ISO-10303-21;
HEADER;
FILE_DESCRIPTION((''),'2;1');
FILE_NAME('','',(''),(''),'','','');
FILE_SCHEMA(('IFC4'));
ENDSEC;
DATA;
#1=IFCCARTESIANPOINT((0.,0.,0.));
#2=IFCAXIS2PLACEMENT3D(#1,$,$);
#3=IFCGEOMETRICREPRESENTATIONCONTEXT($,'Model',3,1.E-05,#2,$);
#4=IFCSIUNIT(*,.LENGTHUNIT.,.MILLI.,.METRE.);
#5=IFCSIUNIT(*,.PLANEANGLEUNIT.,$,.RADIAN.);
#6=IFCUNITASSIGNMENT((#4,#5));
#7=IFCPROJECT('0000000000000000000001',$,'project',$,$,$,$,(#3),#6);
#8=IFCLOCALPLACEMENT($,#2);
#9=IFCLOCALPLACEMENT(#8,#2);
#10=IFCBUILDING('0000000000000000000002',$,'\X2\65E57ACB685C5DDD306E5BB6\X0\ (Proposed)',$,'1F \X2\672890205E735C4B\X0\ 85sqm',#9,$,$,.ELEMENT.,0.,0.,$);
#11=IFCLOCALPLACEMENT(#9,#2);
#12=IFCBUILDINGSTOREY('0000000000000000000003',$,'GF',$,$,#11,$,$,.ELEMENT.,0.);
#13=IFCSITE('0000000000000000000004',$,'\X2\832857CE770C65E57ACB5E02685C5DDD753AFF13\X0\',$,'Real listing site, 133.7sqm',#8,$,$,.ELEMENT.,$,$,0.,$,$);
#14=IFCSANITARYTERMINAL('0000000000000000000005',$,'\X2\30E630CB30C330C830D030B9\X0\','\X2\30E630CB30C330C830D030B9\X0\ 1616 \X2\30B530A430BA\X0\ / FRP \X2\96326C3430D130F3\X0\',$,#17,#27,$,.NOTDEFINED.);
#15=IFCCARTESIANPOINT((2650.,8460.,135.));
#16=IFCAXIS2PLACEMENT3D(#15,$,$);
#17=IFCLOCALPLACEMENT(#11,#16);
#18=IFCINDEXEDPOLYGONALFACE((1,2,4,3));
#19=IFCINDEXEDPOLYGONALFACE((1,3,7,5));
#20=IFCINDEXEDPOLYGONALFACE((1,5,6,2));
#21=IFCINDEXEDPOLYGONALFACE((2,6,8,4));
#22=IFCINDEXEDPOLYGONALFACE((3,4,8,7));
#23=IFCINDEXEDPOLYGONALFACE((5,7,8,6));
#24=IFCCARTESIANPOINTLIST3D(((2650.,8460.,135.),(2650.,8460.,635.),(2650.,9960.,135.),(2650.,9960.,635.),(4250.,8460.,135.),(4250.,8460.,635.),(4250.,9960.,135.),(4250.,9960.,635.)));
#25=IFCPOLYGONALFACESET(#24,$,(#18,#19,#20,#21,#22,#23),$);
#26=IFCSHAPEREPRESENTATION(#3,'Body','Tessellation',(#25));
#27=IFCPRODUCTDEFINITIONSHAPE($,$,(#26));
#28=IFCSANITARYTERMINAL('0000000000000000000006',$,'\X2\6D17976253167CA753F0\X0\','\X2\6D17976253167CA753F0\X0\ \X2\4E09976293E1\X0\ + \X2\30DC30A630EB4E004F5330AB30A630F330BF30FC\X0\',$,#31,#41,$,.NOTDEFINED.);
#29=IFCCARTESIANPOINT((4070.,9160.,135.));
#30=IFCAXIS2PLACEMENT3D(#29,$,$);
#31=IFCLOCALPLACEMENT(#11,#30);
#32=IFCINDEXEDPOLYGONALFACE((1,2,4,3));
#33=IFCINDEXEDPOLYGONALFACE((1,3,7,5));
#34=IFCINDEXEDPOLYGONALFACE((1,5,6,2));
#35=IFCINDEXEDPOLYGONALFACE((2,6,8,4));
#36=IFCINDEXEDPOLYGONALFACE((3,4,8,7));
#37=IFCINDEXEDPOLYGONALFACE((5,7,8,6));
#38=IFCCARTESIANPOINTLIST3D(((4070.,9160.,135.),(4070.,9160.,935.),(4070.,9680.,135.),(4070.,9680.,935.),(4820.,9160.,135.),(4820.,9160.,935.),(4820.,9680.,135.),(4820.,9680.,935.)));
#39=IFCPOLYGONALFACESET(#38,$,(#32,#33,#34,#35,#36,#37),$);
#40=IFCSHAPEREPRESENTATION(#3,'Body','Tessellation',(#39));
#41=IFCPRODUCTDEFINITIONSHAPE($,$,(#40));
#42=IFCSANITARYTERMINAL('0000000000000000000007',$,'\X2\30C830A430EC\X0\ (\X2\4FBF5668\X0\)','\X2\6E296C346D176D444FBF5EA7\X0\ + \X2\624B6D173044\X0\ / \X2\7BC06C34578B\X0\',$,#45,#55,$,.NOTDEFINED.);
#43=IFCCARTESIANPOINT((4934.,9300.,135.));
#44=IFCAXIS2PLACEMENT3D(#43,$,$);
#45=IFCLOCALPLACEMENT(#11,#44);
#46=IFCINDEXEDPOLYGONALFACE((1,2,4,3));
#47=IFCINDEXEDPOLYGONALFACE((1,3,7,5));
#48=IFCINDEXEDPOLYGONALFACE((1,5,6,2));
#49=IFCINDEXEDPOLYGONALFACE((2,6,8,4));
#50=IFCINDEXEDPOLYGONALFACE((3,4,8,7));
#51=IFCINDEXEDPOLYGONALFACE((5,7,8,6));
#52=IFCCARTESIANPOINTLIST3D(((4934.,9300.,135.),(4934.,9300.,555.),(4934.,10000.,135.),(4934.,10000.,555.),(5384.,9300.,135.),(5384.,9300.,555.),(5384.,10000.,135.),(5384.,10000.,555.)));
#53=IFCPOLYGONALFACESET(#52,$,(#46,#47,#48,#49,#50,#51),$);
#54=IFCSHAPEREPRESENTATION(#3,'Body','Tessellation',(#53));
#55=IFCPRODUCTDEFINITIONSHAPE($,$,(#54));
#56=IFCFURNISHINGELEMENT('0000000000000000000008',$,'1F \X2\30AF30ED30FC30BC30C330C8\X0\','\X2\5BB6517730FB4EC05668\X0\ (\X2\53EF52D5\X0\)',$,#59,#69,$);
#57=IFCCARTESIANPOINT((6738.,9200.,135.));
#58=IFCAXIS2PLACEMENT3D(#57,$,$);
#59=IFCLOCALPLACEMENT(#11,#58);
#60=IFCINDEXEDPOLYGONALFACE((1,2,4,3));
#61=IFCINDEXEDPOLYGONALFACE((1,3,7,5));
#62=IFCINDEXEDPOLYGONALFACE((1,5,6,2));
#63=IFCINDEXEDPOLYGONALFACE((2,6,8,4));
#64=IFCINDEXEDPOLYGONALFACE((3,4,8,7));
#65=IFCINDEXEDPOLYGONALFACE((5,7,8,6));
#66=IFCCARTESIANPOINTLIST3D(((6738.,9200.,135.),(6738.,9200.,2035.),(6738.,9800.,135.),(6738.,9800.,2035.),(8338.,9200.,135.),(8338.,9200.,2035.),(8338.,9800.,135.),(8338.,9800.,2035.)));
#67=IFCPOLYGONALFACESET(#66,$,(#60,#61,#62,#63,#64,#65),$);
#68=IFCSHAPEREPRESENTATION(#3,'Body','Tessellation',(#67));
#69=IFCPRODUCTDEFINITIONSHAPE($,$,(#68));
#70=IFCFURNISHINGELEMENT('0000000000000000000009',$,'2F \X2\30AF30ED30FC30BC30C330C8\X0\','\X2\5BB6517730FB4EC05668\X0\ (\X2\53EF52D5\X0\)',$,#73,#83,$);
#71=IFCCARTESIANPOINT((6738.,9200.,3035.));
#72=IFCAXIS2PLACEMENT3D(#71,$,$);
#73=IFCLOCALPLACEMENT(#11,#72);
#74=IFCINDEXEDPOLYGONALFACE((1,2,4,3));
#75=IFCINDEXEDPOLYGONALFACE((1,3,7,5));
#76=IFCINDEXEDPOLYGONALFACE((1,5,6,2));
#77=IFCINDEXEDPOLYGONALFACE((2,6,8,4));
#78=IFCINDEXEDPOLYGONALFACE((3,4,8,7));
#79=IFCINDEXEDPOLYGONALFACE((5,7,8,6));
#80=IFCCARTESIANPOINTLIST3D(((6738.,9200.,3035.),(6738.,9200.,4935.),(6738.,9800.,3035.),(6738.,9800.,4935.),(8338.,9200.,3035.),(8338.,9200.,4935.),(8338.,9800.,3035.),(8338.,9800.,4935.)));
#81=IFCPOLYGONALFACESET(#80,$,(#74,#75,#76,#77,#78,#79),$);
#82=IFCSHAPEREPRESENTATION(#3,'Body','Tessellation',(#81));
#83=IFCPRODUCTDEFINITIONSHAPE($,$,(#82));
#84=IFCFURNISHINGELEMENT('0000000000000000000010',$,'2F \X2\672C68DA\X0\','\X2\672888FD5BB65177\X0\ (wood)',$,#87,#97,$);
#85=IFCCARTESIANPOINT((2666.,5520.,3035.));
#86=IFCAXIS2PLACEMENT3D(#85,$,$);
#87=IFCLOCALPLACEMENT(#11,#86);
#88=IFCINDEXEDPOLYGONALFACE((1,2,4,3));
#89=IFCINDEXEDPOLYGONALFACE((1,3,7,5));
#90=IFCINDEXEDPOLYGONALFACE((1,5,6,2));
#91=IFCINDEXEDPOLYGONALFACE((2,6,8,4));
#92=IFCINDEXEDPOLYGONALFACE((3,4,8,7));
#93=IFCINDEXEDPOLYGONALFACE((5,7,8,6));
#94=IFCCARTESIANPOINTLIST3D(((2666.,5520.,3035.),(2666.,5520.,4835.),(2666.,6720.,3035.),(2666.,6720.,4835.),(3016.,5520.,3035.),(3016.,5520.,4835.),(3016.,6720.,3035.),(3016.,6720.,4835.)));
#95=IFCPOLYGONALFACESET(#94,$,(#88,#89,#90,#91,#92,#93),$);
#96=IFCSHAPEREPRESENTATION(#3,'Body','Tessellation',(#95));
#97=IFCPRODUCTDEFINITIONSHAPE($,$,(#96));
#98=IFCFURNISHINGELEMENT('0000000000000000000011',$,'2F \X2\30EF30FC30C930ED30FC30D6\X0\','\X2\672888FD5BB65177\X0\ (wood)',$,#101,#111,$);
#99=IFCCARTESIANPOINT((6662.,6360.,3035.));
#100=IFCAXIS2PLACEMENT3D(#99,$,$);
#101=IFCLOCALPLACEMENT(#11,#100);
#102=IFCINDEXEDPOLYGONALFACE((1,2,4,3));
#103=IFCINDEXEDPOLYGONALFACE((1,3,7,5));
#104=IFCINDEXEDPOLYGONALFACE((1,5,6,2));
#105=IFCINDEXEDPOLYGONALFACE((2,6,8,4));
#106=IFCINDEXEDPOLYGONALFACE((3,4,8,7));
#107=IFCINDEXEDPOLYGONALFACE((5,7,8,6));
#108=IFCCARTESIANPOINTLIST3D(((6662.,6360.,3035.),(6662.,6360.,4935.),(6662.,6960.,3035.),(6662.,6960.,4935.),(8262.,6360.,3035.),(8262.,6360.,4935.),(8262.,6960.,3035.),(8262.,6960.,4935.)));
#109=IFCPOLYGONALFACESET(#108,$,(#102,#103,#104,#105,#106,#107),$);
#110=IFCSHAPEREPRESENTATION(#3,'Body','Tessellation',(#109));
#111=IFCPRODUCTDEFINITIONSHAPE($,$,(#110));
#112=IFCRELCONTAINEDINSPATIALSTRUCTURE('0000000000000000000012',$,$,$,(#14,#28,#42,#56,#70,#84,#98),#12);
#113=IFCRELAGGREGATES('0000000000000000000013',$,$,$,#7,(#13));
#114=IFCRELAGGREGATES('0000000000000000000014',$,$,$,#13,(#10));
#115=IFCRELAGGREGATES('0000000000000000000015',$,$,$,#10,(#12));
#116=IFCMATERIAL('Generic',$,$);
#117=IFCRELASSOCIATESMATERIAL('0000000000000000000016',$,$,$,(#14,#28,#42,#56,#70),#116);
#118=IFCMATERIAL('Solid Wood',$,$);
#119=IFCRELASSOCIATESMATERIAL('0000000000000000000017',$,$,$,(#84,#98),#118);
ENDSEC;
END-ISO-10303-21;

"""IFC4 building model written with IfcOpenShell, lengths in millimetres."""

from ifc_helpers import new_model, si_unit, frame, frame_2d, origin, place, context, project, spatial, rectangle, extrude, material, element, save


model = new_model("IFC4")

# Units and contexts
model_context = context("Model", 3, precision=1e-05, world=origin())
ifc_project = project(units=[si_unit("LENGTHUNIT", "METRE", prefix="MILLI"), si_unit("PLANEANGLEUNIT", "RADIAN")], contexts=[model_context])

# Site, building, storey
site_placement = place(None, origin())
site = spatial("IfcSite", under=ifc_project, at=site_placement, Name="茨城県日立市桜川町３", ObjectType="Real listing site, 133.7sqm", CompositionType="ELEMENT", RefElevation=0.0)
building_placement = place(site_placement, origin())
building = spatial("IfcBuilding", under=site, at=building_placement, Name="日立桜川の家 (Proposed)", ObjectType="1F 木造平屋 85sqm", CompositionType="ELEMENT", ElevationOfRefHeight=0.0, ElevationOfTerrain=0.0)
storey_placement = place(building_placement, origin())
storey = spatial("IfcBuildingStorey", under=building, at=storey_placement, Name="GF", CompositionType="ELEMENT", Elevation=0.0)

# Shared definitions
ifc_material_1 = material(Name="Solid Wood")

# Shared definitions
ifc_material_2 = material(Name="Generic")

# Sanitary terminals
sanitary_terminal_1_placement = place(storey_placement, frame((2650.0, 8460.0, 135.0)))
element("IfcSanitaryTerminal", 1, at=sanitary_terminal_1_placement, inside=storey, material=ifc_material_2, Name="ユニットバス", Description="ユニットバス 1616 サイズ / FRP 防水パン", PredefinedType="NOTDEFINED", context=model_context, shape_type="SweptSolid", body=[
    extrude(rectangle(XDim=1600.0, YDim=1500.0, at=frame_2d((800.0, 750.0))), frame((2650.0, 8460.0, 135.0)), (0.0, 0.0, 1.0), 500.0),
])
sanitary_terminal_2_placement = place(storey_placement, frame((4070.0, 9160.0, 135.0)))
element("IfcSanitaryTerminal", 2, at=sanitary_terminal_2_placement, inside=storey, material=ifc_material_2, Name="洗面化粧台", Description="洗面化粧台 三面鏡 + ボウル一体カウンター", PredefinedType="NOTDEFINED", context=model_context, shape_type="SweptSolid", body=[
    extrude(rectangle(XDim=750.0, YDim=520.0, at=frame_2d((375.0, 260.0))), frame((4070.0, 9160.0, 135.0)), (0.0, 0.0, 1.0), 800.0),
])
sanitary_terminal_3_placement = place(storey_placement, frame((4934.0, 9300.0, 135.0)))
element("IfcSanitaryTerminal", 3, at=sanitary_terminal_3_placement, inside=storey, material=ifc_material_2, Name="トイレ (便器)", Description="温水洗浄便座 + 手洗い / 節水型", PredefinedType="NOTDEFINED", context=model_context, shape_type="SweptSolid", body=[
    extrude(rectangle(XDim=450.0, YDim=700.0, at=frame_2d((225.0, 350.0))), frame((4934.0, 9300.0, 135.0)), (0.0, 0.0, 1.0), 420.0),
])

# Furnishing elements
furnishing_1_placement = place(storey_placement, frame((6738.0, 9200.0, 135.0)))
element("IfcFurnishingElement", 4, at=furnishing_1_placement, inside=storey, material=ifc_material_2, Name="1F クローゼット", Description="家具・什器 (可動)", context=model_context, shape_type="SweptSolid", body=[
    extrude(rectangle(XDim=1600.0, YDim=600.0, at=frame_2d((800.0, 300.0))), frame((6738.0, 9200.0, 135.0)), (0.0, 0.0, 1.0), 1900.0),
])
furnishing_2_placement = place(storey_placement, frame((6738.0, 9200.0, 3035.0)))
element("IfcFurnishingElement", 5, at=furnishing_2_placement, inside=storey, material=ifc_material_2, Name="2F クローゼット", Description="家具・什器 (可動)", context=model_context, shape_type="SweptSolid", body=[
    extrude(rectangle(XDim=1600.0, YDim=600.0, at=frame_2d((800.0, 300.0))), frame((6738.0, 9200.0, 3035.0)), (0.0, 0.0, 1.0), 1900.0),
])
furnishing_3_placement = place(storey_placement, frame((2666.0, 5520.0, 3035.0)))
element("IfcFurnishingElement", 6, at=furnishing_3_placement, inside=storey, material=ifc_material_1, Name="2F 本棚", Description="木製家具 (wood)", context=model_context, shape_type="SweptSolid", body=[
    extrude(rectangle(XDim=350.0, YDim=1200.0, at=frame_2d((175.0, 600.0))), frame((2666.0, 5520.0, 3035.0)), (0.0, 0.0, 1.0), 1800.0),
])
furnishing_4_placement = place(storey_placement, frame((6662.0, 6360.0, 3035.0)))
element("IfcFurnishingElement", 7, at=furnishing_4_placement, inside=storey, material=ifc_material_1, Name="2F ワードローブ", Description="木製家具 (wood)", context=model_context, shape_type="SweptSolid", body=[
    extrude(rectangle(XDim=1600.0, YDim=600.0, at=frame_2d((800.0, 300.0))), frame((6662.0, 6360.0, 3035.0)), (0.0, 0.0, 1.0), 1900.0),
])

save(model, "model.ifc")
